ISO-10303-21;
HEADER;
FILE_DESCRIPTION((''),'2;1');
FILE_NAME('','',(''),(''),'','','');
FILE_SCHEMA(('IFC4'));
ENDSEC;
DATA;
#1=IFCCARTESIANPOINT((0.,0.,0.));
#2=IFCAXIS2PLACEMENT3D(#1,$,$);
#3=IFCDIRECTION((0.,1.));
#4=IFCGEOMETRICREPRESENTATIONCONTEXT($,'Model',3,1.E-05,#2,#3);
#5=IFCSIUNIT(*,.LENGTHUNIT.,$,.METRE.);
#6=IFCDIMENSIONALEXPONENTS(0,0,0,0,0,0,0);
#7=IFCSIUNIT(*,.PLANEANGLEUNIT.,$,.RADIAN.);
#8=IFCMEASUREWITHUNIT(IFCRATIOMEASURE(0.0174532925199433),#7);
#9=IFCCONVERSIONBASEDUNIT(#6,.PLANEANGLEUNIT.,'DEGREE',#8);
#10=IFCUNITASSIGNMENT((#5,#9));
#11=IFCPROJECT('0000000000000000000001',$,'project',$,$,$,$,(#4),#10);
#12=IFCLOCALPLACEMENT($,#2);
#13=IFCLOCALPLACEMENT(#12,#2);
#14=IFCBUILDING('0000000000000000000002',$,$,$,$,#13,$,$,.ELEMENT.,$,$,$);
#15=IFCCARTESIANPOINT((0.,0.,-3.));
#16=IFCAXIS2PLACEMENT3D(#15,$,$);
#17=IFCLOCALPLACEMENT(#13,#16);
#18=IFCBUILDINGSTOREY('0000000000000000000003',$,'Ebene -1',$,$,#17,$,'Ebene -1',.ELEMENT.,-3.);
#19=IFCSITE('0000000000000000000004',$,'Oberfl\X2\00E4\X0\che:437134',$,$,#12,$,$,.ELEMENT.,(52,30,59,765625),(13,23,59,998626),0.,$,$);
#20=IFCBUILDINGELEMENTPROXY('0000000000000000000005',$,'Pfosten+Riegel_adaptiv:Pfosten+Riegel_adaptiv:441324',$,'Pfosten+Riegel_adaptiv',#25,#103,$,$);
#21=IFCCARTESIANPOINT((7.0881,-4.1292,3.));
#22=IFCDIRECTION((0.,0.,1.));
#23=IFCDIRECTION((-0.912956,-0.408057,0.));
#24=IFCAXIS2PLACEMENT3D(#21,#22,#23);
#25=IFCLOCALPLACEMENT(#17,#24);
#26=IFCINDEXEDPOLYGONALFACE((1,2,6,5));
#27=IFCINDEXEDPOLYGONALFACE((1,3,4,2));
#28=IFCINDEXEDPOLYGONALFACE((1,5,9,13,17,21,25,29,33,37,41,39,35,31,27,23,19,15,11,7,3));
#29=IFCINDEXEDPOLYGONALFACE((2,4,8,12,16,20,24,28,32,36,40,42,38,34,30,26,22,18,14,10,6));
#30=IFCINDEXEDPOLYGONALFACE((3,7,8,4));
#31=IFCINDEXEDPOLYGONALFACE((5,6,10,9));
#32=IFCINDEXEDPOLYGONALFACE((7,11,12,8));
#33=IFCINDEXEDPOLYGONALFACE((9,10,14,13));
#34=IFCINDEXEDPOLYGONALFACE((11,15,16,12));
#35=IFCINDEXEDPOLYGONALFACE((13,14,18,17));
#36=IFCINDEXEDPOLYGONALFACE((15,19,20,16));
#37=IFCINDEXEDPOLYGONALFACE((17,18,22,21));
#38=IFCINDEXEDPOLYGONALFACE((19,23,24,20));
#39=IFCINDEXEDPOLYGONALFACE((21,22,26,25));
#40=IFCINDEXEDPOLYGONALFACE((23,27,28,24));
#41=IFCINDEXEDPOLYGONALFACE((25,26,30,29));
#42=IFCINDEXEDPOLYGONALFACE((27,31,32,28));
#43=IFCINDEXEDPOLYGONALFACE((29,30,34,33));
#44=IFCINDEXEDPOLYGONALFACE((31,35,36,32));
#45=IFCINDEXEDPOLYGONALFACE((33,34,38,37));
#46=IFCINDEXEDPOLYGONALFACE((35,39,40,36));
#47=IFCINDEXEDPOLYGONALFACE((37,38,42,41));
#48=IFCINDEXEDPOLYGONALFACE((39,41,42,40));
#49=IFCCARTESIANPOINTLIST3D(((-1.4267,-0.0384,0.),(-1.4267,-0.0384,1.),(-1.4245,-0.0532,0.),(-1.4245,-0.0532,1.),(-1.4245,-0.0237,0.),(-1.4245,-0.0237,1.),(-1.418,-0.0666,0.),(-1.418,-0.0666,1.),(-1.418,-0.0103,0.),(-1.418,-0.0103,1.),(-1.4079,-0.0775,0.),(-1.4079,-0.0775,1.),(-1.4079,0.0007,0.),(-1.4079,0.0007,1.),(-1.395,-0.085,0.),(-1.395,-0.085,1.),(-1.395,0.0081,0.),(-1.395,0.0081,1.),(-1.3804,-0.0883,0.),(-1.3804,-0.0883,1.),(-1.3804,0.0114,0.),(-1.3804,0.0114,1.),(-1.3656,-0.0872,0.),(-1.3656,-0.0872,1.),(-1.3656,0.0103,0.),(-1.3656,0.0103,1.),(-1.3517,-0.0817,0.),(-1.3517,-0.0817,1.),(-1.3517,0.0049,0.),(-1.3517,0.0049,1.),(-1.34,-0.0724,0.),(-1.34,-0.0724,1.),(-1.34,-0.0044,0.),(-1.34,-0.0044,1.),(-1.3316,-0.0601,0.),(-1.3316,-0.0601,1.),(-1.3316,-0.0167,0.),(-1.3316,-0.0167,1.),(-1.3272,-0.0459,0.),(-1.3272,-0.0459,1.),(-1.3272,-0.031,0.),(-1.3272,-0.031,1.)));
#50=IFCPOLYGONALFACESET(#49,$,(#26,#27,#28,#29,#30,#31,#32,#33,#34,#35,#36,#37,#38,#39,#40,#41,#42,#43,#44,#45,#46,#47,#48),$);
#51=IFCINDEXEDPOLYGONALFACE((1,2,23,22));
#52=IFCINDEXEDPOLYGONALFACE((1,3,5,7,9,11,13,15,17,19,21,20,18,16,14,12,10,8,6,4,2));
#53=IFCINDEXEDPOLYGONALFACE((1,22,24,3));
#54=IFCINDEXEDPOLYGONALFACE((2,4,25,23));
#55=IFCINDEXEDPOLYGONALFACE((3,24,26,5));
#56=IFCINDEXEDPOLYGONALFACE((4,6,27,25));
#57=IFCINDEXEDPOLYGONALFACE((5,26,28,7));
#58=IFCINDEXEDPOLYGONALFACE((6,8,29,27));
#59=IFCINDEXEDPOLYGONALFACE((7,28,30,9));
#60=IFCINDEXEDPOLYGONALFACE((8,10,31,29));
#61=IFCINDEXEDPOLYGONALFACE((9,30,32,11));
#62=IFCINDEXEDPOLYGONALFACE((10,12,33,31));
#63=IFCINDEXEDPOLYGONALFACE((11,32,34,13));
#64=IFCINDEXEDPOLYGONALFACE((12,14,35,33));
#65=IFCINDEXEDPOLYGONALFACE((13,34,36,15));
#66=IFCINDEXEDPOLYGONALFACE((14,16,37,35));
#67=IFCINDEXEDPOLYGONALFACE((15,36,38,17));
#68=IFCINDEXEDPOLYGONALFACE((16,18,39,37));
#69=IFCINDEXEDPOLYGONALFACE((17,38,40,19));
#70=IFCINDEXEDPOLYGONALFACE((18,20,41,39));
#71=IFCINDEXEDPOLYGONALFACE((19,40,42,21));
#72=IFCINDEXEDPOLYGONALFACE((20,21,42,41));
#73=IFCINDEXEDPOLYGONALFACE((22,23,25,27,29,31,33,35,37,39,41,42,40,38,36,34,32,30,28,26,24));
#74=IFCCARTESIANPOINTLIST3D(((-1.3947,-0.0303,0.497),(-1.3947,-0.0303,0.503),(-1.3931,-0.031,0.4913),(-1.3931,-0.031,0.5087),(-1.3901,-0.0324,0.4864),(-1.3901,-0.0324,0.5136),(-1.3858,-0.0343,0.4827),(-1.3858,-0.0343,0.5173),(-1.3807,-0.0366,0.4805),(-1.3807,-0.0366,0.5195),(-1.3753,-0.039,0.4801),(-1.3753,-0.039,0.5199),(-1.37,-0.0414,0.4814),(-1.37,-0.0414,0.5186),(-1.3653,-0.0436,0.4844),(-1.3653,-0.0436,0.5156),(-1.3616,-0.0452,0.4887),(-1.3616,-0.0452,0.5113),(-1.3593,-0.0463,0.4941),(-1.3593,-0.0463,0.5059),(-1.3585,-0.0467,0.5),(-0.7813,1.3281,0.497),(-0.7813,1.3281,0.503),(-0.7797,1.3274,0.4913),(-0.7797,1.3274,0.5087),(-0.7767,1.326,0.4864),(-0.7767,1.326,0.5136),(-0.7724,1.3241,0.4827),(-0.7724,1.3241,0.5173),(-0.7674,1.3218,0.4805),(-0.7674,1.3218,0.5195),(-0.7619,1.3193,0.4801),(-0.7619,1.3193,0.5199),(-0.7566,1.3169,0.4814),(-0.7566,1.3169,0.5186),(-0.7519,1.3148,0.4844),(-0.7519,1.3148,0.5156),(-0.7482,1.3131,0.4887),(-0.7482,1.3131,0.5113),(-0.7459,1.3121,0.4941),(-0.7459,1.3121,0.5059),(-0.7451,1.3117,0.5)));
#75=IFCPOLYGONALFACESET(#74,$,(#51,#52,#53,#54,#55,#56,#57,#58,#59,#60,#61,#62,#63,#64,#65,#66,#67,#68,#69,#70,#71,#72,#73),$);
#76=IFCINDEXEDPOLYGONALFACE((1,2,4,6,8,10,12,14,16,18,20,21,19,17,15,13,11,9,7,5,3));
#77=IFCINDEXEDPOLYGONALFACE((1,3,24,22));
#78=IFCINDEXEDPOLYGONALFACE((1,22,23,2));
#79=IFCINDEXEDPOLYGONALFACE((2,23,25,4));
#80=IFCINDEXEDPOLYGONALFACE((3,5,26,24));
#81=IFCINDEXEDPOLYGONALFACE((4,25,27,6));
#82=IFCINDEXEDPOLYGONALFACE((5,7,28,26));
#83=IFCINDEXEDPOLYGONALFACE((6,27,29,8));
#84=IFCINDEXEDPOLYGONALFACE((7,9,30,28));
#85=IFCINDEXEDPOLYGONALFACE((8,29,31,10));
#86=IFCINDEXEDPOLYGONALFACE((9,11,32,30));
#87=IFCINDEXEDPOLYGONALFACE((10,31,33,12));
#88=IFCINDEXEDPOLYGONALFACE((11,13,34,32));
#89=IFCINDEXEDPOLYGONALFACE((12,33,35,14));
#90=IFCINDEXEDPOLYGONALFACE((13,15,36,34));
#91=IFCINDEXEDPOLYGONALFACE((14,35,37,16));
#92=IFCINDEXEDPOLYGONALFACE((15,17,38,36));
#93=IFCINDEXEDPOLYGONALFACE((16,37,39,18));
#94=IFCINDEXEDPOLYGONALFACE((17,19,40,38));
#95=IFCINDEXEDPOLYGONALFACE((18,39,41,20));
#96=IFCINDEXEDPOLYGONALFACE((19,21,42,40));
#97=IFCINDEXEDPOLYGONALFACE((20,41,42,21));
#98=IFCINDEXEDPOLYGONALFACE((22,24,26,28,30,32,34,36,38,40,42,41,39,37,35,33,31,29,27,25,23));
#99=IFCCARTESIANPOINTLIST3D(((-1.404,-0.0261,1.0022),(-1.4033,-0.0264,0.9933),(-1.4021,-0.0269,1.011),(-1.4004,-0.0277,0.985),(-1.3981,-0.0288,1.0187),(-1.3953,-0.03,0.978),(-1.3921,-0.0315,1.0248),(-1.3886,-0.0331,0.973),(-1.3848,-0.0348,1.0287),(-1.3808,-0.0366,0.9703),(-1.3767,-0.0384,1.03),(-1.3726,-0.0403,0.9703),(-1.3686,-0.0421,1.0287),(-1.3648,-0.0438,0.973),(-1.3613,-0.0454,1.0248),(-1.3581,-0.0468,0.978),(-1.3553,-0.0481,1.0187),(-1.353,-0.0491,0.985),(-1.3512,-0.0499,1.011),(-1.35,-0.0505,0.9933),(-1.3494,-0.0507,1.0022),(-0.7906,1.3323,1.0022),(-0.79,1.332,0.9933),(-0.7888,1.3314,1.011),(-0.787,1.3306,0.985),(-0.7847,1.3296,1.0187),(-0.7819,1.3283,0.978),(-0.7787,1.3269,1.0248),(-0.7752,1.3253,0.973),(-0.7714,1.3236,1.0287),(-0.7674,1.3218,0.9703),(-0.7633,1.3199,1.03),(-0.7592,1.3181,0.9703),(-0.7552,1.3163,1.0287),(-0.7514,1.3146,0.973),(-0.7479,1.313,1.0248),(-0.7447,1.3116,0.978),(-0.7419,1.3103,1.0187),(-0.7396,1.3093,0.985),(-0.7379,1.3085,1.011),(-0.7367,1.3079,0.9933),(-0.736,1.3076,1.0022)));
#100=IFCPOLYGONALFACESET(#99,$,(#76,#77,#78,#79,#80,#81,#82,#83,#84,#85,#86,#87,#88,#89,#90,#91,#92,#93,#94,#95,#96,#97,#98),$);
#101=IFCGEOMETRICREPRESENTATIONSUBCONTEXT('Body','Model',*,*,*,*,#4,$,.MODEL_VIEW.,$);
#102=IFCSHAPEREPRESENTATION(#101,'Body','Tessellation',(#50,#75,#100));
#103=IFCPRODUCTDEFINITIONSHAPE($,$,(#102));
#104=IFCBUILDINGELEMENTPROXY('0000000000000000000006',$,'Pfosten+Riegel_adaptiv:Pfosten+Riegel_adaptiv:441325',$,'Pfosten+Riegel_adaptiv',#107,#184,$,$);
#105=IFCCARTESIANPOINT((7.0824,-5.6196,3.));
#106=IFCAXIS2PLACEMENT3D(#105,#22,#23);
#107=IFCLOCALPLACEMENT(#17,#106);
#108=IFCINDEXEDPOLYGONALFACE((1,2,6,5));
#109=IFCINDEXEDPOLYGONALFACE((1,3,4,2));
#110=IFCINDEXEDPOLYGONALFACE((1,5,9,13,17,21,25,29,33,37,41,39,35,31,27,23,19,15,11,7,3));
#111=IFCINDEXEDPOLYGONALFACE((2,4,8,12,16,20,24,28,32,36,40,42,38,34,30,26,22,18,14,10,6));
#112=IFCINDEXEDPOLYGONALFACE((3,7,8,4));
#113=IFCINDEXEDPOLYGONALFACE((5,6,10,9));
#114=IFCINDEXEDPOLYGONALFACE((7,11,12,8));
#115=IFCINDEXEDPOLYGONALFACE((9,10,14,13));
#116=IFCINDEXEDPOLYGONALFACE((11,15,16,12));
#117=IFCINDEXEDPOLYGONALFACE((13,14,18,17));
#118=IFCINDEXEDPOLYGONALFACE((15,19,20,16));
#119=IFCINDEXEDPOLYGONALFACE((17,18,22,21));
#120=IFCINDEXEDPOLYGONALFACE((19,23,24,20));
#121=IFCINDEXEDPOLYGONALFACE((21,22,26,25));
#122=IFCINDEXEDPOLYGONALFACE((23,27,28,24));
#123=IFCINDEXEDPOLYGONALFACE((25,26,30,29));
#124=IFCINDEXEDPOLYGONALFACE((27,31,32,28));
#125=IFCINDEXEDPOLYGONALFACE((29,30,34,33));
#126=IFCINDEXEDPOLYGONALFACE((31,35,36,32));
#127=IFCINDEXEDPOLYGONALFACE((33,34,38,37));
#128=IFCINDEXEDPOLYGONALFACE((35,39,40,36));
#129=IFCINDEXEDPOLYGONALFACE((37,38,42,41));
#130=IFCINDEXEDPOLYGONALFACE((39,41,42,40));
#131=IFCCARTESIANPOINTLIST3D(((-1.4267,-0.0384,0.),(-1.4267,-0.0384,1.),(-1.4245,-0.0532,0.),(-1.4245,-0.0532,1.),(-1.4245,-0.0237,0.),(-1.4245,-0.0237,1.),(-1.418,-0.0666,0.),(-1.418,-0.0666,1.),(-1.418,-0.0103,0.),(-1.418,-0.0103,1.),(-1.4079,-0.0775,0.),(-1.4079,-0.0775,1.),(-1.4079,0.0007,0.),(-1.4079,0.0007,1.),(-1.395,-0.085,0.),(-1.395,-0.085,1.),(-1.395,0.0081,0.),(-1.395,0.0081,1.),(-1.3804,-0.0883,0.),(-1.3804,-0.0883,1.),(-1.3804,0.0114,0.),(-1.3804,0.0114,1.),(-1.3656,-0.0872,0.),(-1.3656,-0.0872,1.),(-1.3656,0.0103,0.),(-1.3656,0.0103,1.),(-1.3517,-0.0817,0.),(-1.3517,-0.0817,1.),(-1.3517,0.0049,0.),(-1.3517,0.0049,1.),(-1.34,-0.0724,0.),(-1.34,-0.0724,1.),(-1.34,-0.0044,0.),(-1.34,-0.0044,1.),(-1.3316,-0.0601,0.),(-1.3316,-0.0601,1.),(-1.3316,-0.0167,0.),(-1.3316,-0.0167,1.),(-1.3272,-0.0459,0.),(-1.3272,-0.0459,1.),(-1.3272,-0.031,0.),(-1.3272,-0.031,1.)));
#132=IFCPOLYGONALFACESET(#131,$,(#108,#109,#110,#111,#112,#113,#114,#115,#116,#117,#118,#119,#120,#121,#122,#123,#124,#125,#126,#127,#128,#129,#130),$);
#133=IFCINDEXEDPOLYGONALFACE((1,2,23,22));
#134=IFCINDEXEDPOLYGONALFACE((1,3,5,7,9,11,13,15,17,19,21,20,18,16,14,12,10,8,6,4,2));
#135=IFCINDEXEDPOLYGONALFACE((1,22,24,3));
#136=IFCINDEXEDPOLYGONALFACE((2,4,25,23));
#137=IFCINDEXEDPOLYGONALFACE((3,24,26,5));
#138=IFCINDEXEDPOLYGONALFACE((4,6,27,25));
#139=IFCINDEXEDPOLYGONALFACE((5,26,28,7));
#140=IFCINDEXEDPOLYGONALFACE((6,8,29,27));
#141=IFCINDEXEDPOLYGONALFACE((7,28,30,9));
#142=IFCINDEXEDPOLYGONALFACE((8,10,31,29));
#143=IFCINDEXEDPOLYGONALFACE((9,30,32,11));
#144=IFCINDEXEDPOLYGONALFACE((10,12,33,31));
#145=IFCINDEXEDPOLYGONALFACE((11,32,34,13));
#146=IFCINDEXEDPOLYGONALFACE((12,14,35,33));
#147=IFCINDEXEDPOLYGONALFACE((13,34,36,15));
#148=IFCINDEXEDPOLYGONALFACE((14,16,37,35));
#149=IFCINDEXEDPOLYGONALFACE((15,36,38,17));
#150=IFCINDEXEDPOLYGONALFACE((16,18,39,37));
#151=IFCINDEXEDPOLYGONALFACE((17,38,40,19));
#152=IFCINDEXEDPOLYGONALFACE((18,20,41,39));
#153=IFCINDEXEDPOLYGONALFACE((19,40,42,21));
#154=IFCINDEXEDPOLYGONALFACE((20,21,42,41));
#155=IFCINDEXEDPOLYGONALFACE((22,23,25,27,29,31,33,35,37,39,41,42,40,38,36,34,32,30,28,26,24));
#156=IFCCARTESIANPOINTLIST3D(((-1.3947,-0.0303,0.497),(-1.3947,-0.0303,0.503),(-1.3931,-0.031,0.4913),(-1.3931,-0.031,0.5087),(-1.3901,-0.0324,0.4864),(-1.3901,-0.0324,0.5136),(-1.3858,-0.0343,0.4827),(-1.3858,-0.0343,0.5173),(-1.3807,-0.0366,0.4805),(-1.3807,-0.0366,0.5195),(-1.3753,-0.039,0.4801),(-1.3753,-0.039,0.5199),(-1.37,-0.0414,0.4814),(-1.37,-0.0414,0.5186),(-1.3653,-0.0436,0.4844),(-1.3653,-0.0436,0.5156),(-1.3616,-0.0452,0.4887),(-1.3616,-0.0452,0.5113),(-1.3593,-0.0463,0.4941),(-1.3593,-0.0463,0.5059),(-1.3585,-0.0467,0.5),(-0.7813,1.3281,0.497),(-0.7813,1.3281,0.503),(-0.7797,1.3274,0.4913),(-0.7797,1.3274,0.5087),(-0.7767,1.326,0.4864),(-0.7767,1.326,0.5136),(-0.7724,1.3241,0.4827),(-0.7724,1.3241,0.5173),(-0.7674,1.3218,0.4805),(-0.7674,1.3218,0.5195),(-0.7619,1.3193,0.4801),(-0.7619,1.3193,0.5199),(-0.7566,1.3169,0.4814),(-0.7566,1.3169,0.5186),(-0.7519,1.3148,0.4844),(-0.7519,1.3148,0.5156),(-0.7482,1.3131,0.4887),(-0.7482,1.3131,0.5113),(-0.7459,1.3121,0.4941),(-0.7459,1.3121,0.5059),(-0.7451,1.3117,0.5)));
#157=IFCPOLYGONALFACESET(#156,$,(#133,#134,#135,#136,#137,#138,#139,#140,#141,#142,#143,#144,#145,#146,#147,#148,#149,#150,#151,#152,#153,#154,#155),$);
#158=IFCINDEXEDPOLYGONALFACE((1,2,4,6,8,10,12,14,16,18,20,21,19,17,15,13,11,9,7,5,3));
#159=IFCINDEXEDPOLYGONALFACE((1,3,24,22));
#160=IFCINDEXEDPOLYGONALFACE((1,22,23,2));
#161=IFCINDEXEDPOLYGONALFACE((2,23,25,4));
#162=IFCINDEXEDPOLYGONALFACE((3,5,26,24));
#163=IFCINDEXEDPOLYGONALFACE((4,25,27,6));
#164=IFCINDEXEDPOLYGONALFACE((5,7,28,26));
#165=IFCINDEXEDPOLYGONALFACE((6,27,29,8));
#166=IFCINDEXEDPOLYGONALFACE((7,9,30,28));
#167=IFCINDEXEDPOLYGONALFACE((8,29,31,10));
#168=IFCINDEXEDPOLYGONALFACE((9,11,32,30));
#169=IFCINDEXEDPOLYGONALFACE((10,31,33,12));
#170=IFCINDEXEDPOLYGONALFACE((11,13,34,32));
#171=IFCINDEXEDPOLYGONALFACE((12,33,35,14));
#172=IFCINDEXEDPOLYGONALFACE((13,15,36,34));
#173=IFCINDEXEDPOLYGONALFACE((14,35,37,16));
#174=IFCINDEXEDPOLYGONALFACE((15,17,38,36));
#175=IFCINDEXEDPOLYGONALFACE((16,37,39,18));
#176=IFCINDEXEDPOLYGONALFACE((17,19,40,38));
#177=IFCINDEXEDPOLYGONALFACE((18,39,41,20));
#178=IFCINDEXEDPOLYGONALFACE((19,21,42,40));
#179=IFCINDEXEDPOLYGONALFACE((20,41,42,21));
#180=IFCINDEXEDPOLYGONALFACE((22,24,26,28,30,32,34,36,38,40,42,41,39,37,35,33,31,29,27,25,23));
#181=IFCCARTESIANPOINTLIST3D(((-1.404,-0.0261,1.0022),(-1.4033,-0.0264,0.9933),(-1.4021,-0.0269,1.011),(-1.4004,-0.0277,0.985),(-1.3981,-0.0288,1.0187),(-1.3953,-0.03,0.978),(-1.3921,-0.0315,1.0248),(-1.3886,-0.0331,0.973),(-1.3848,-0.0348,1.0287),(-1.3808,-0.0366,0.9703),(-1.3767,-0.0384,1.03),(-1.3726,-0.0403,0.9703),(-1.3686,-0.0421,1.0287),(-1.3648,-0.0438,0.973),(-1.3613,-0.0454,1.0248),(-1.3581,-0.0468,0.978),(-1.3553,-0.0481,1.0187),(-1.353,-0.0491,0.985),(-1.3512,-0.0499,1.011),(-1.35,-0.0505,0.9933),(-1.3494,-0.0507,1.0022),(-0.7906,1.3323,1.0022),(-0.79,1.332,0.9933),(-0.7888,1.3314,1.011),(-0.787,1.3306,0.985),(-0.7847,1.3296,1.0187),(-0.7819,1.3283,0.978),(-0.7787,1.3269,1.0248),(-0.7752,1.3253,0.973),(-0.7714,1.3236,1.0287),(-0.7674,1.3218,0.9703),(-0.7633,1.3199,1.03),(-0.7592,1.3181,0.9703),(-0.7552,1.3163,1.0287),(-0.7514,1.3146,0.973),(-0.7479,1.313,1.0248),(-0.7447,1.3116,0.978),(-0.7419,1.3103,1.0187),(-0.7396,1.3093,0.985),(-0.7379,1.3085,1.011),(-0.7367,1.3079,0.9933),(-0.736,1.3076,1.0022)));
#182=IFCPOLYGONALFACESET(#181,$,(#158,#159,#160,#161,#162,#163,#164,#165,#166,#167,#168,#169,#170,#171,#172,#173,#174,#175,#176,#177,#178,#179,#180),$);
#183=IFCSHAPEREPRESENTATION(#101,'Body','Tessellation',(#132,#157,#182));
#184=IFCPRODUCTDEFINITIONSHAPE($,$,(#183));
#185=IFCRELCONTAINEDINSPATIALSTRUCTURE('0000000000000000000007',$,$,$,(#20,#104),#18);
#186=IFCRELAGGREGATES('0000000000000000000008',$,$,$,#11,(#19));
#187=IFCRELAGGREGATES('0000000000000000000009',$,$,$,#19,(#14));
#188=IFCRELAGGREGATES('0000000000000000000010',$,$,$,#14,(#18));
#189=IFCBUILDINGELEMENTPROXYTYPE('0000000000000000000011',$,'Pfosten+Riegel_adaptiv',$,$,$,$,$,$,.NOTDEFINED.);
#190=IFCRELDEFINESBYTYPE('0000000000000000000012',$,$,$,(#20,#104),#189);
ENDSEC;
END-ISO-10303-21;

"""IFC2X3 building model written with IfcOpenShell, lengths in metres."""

from ifc_helpers import new_model, entity, si_unit, converted_unit, direction, frame, frame_2d, origin, place, context, subcontext, project, spatial, circle, extrude, source, transform, mapped, type_object, type_shapes, element, save


model = new_model("IFC2X3")

# Units and contexts
model_context = context("Model", 3, precision=1e-05, world=origin(), true_north=direction((0.0, 1.0)))
body_context = subcontext(model_context, "Body", "Model", "MODEL_VIEW")
ifc_project = project(units=[si_unit("LENGTHUNIT", "METRE"), converted_unit("PLANEANGLEUNIT", "DEGREE", entity("IfcRatioMeasure", 0.0174532925199433), si_unit("PLANEANGLEUNIT", "RADIAN"), dimensions=[0, 0, 0, 0, 0, 0, 0])], contexts=[model_context])

# Site, building, storey
site_placement = place(None, origin())
site = spatial("IfcSite", under=ifc_project, at=site_placement, Name="Oberfläche:437134", CompositionType="ELEMENT", RefLatitude=(52, 30, 59, 765625), RefLongitude=(13, 23, 59, 998626), RefElevation=0.0)
building_placement = place(site_placement, origin())
building = spatial("IfcBuilding", under=site, at=building_placement, CompositionType="ELEMENT")
storey_placement = place(building_placement, frame((0.0, 0.0, -3.0)))
storey = spatial("IfcBuildingStorey", under=building, at=storey_placement, Name="Ebene -1", LongName="Ebene -1", CompositionType="ELEMENT", Elevation=-3.0)

# Building element proxies
building_element_proxy_type_1 = type_object("IfcBuildingElementProxyType", Name="Pfosten+Riegel_adaptiv", PredefinedType="NOTDEFINED")
shared_shape_1 = source(origin(), body_context, "Body", "SweptSolid", [
    extrude(circle(Radius=0.05, at=frame_2d((0.0, 0.0), x_axis=(1.0, 0.0))), frame((-1.3767, -0.0384, 0.0), z_axis=(0.0, 0.0, 1.0), x_axis=(-1.0, 0.0, 0.0)), (0.0, 0.0, 1.0), 1.0),
    extrude(circle(Radius=0.02, at=frame_2d((0.0, 0.0), x_axis=(1.0, 0.0))), frame((-1.3767, -0.0384, 0.5), z_axis=(0.411546, 0.911389, 0.0), x_axis=(0.911389, -0.411546, 0.0)), (0.0, 0.0, 1.0), 1.4904),
    extrude(circle(Radius=0.03, at=frame_2d((0.0, 0.0), x_axis=(1.0, 0.0))), frame((-1.3767, -0.0384, 1.0), z_axis=(0.411546, 0.911389, 0.0), x_axis=(0.0, 0.0, 1.0)), (0.0, 0.0, 1.0), 1.4904),
])
type_shapes(building_element_proxy_type_1, [shared_shape_1])
for number, where, z_axis, x_axis, name in (
    (1, (7.0881, -4.1292, 3.0), (0.0, 0.0, 1.0), (-0.912956, -0.408057, 0.0), "Pfosten+Riegel_adaptiv:Pfosten+Riegel_adaptiv:441324"),
    (2, (7.0824, -5.6196, 3.0), (0.0, 0.0, 1.0), (-0.912956, -0.408057, 0.0), "Pfosten+Riegel_adaptiv:Pfosten+Riegel_adaptiv:441325"),
):
    element("IfcBuildingElementProxy", number, at=place(storey_placement, frame(where, z_axis=z_axis, x_axis=x_axis)), inside=storey, type_object=building_element_proxy_type_1, Name=name, ObjectType="Pfosten+Riegel_adaptiv", context=body_context, shape_type="MappedRepresentation", body=[
        mapped(shared_shape_1, transform((0.0, 0.0, 0.0), scale=1.0)),
    ])

save(model, "model.ifc")
